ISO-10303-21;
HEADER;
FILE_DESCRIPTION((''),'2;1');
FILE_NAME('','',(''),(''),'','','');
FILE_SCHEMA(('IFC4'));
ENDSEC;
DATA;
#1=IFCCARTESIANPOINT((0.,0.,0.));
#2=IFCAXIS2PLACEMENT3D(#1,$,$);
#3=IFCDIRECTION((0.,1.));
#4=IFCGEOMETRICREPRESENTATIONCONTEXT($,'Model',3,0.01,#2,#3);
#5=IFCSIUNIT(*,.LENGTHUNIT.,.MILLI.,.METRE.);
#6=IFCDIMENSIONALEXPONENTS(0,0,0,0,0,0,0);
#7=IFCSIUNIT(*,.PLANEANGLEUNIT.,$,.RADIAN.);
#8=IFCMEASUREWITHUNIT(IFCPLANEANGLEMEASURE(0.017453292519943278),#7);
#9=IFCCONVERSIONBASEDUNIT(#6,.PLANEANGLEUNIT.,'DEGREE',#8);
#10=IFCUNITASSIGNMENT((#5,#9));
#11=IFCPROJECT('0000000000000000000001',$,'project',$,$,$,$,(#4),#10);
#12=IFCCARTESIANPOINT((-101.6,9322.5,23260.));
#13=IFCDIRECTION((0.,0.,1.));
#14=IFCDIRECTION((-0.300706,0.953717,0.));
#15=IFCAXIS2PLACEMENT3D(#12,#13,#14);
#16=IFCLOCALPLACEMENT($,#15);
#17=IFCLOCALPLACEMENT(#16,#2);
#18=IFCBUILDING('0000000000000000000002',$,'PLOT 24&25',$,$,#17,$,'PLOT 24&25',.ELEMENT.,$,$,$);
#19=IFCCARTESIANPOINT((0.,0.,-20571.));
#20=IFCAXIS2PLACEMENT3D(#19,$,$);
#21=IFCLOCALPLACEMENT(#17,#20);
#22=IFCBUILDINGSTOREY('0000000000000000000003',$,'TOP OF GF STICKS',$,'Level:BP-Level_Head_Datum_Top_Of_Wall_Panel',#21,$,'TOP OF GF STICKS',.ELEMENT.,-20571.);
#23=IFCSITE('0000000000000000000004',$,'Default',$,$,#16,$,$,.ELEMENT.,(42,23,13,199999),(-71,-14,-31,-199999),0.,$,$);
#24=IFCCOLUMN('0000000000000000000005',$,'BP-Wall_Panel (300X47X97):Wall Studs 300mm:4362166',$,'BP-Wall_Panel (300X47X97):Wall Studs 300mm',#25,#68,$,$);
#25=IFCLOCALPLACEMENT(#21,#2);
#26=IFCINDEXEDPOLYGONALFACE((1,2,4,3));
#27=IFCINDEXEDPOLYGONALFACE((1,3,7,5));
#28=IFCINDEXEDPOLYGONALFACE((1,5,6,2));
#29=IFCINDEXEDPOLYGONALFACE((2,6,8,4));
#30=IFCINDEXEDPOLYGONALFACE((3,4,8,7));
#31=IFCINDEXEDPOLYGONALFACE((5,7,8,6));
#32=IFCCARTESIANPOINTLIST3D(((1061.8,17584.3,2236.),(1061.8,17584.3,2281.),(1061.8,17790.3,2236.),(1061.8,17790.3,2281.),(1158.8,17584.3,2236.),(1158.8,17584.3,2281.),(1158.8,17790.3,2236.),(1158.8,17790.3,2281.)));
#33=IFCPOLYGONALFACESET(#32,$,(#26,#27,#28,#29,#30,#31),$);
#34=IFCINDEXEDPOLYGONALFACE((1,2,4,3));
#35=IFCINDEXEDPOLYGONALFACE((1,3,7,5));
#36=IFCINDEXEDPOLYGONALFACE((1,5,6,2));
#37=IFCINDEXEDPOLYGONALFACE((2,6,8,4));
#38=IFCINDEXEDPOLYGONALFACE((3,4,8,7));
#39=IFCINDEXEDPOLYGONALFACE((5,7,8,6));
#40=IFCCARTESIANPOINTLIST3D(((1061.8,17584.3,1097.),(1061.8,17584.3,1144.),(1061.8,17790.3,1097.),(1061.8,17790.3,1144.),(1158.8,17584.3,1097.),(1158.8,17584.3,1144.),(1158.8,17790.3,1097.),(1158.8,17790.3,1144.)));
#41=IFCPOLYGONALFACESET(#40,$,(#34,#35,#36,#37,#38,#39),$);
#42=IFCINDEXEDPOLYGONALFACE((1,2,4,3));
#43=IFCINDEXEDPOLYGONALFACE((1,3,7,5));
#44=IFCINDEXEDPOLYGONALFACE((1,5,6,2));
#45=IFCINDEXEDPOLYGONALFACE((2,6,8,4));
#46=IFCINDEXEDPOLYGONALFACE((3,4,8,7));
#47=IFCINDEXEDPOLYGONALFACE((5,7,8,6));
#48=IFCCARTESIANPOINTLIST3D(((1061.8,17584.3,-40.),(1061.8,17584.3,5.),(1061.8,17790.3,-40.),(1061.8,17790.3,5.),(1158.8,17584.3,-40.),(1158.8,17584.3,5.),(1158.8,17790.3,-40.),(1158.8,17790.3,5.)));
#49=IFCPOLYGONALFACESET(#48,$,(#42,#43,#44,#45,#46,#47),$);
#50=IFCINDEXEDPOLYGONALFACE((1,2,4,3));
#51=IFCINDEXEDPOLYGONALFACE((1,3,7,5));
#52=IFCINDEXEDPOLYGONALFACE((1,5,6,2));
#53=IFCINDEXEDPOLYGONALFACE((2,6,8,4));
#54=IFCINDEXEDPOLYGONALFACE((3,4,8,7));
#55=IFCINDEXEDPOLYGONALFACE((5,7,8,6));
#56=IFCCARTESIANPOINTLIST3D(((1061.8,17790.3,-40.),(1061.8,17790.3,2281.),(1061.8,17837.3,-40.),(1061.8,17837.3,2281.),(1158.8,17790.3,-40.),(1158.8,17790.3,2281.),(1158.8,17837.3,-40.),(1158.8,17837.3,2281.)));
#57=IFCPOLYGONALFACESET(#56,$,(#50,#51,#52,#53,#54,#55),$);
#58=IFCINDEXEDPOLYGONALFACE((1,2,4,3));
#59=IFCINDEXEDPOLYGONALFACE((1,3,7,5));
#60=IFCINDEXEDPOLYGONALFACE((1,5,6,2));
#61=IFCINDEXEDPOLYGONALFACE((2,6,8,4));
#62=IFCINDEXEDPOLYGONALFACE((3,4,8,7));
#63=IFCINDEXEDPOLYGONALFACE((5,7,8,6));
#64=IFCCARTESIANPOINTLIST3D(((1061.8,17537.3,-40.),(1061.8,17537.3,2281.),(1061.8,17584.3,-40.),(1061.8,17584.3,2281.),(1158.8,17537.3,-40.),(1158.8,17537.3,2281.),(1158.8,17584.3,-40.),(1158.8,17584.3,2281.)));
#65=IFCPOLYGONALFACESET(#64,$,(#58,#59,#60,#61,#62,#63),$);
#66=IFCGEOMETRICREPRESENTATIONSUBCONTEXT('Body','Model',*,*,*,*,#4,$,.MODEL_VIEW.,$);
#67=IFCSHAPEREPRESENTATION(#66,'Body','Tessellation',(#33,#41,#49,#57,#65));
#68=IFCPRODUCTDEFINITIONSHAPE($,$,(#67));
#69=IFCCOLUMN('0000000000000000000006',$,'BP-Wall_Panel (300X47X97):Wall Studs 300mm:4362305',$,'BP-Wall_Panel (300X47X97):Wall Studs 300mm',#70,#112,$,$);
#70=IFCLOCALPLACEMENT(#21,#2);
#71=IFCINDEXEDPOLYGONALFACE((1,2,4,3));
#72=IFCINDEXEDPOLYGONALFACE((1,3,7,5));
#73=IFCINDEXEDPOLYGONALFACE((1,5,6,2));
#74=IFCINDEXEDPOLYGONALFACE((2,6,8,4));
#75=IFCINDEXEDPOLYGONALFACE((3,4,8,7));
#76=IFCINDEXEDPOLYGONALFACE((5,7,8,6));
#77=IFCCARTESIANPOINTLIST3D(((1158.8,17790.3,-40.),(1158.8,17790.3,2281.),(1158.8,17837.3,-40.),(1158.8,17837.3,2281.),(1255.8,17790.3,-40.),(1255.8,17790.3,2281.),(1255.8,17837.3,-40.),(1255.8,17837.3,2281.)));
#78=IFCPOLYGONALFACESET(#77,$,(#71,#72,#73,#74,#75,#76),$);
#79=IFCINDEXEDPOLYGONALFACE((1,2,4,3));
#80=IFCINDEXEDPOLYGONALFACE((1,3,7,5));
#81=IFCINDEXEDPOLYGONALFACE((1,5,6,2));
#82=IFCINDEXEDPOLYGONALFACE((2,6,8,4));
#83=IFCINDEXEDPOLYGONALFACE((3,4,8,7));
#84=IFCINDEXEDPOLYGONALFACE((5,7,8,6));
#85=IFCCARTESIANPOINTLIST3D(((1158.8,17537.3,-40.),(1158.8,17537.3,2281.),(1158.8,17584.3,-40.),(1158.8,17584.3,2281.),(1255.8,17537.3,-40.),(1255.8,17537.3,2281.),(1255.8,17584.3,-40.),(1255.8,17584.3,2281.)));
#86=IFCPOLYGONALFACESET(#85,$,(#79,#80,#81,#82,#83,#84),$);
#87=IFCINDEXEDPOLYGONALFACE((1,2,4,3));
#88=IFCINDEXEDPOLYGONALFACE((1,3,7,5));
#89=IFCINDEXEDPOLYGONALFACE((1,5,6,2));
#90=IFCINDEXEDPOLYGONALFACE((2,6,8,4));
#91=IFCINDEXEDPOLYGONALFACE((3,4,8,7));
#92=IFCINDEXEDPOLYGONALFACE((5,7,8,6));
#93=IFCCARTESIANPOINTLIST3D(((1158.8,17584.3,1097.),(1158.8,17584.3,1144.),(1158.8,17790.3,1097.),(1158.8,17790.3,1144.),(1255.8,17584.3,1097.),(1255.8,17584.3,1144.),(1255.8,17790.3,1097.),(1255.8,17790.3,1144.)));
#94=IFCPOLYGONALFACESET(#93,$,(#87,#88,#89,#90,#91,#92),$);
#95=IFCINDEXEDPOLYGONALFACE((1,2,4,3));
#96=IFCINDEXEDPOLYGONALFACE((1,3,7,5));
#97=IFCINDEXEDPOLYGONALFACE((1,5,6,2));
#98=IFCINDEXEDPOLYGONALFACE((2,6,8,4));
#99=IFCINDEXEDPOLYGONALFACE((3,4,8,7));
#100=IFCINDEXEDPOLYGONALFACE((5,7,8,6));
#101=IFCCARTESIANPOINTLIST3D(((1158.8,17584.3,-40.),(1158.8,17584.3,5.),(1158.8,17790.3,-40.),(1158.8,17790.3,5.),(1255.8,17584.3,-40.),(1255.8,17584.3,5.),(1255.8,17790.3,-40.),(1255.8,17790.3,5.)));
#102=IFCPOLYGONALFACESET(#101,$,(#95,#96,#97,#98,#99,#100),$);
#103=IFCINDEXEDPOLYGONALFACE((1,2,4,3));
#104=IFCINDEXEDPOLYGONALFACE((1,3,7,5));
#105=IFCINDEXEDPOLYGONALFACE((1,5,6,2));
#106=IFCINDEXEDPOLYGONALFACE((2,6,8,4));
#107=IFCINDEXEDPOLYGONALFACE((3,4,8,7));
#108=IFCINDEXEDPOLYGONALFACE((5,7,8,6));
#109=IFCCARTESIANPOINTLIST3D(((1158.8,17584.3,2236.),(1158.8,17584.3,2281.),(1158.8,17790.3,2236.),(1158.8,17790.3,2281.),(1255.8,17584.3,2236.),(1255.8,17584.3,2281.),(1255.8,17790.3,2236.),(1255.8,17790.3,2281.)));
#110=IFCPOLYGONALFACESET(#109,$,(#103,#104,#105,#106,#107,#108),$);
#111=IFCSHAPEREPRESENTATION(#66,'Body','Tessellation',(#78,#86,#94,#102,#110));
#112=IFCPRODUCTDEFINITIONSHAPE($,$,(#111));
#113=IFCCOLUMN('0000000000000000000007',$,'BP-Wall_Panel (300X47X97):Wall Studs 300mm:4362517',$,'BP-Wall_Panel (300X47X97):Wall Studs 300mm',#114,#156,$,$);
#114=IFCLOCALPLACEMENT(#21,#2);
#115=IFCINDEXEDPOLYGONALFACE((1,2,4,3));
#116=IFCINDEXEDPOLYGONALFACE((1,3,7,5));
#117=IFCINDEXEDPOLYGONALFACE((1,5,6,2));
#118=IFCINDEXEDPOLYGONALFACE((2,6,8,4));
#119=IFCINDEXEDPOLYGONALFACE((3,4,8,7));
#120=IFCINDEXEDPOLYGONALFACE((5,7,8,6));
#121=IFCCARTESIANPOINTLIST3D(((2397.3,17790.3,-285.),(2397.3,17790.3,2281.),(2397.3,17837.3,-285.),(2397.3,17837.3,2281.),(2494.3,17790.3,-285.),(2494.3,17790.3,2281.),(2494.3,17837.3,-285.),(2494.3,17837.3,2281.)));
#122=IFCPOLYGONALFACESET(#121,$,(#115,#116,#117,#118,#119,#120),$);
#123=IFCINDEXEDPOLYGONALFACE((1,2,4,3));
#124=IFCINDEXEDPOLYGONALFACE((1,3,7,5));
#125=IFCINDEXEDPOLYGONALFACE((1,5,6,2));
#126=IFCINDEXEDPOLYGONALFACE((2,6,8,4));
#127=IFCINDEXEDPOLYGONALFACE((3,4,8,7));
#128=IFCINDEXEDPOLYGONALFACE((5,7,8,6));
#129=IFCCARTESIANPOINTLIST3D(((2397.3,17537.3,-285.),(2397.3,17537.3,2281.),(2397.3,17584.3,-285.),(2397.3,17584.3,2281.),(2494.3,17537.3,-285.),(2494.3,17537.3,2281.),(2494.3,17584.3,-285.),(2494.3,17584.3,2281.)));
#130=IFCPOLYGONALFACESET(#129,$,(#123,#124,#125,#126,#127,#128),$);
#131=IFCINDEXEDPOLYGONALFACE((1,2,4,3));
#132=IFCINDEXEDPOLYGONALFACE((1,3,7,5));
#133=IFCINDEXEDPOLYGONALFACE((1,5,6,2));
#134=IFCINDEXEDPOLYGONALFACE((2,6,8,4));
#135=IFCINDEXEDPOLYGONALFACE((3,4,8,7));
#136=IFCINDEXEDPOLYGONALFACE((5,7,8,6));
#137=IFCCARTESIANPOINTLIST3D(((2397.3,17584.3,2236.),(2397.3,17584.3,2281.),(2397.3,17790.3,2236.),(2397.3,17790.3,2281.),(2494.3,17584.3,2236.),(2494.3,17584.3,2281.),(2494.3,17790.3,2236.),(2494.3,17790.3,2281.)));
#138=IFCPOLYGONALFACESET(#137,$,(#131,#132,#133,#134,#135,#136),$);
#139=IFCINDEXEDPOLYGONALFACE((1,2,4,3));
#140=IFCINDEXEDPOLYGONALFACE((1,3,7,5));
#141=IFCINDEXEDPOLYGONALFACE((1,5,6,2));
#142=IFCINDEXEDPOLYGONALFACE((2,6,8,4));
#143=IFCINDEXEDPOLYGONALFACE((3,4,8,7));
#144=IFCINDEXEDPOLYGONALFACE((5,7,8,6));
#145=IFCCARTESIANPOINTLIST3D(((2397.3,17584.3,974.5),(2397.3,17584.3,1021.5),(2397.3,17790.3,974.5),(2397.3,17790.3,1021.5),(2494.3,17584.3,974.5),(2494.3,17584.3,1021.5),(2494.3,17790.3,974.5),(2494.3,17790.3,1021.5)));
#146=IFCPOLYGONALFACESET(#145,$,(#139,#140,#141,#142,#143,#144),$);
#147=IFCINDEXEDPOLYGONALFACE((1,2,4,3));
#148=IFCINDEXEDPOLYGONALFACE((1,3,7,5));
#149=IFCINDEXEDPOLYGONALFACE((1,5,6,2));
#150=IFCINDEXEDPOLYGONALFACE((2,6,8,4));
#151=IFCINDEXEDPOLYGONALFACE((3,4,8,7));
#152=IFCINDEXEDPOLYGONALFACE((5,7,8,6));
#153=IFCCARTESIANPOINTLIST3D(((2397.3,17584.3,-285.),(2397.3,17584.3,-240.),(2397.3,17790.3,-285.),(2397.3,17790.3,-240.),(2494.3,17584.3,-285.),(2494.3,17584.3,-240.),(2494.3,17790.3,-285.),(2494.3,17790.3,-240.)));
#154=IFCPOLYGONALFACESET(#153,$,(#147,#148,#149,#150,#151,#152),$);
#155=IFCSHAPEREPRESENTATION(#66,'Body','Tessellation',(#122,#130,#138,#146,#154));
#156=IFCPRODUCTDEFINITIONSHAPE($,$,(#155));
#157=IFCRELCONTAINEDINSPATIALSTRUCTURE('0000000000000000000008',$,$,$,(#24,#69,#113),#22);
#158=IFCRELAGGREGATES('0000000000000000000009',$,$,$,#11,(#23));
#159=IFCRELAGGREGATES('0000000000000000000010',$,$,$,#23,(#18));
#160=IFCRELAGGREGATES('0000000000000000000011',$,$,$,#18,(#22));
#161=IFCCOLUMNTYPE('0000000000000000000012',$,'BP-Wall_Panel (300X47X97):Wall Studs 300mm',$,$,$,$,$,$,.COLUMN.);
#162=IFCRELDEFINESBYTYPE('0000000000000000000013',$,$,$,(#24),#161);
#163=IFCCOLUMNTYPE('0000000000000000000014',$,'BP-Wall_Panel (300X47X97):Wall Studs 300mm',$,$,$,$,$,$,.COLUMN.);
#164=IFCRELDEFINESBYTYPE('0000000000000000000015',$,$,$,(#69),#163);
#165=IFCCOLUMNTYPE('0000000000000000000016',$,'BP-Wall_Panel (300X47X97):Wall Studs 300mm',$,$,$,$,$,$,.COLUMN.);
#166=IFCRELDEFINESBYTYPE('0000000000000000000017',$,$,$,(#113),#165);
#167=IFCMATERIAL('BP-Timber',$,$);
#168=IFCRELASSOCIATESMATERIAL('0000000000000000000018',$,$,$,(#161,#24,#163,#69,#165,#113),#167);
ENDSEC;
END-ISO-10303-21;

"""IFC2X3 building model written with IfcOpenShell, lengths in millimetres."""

from ifc_helpers import new_model, entity, si_unit, converted_unit, direction, frame, frame_2d, origin, place, context, subcontext, project, spatial, rectangle, extrude, source, transform, mapped, material, type_object, type_shapes, element, save


model = new_model("IFC2X3")

# Units and contexts
model_context = context("Model", 3, precision=0.01, world=origin(), true_north=direction((0.0, 1.0)))
body_context = subcontext(model_context, "Body", "Model", "MODEL_VIEW")
ifc_project = project(units=[si_unit("LENGTHUNIT", "METRE", prefix="MILLI"), converted_unit("PLANEANGLEUNIT", "DEGREE", entity("IfcPlaneAngleMeasure", 0.017453292519943278), si_unit("PLANEANGLEUNIT", "RADIAN"), dimensions=[0, 0, 0, 0, 0, 0, 0])], contexts=[model_context])

# Site, building, storey
site_placement = place(None, frame((-101.6, 9322.5, 23260.0), z_axis=(0.0, 0.0, 1.0), x_axis=(-0.300706, 0.953717, 0.0)))
site = spatial("IfcSite", under=ifc_project, at=site_placement, Name="Default", CompositionType="ELEMENT", RefLatitude=(42, 23, 13, 199999), RefLongitude=(-71, -14, -31, -199999), RefElevation=0.0)
building_placement = place(site_placement, origin())
building = spatial("IfcBuilding", under=site, at=building_placement, Name="PLOT 24&25", LongName="PLOT 24&25", CompositionType="ELEMENT")
storey_placement = place(building_placement, frame((0.0, 0.0, -20571.0)))
storey = spatial("IfcBuildingStorey", under=building, at=storey_placement, Name="TOP OF GF STICKS", ObjectType="Level:BP-Level_Head_Datum_Top_Of_Wall_Panel", LongName="TOP OF GF STICKS", CompositionType="ELEMENT", Elevation=-20571.0)

# Columns
ifc_material_1 = material(Name="BP-Timber")
column_type_1 = type_object("IfcColumnType", Name="BP-Wall_Panel (300X47X97):Wall Studs 300mm", PredefinedType="COLUMN", material=ifc_material_1)
shared_shape_1 = source(origin(), body_context, "Body", "SweptSolid", [
    extrude(rectangle(XDim=206.0, YDim=97.0, at=frame_2d((0.0, 0.0), x_axis=(1.0, 0.0))), frame((1110.3, 17687.3, -18335.0), z_axis=(0.0, 0.0, 1.0), x_axis=(0.0, -1.0, 0.0)), (0.0, 0.0, 1.0), 45.0),
    extrude(rectangle(XDim=206.0, YDim=97.0, at=frame_2d((0.0, 0.0), x_axis=(1.0, 0.0))), frame((1110.3, 17687.3, -19474.0), z_axis=(0.0, 0.0, 1.0), x_axis=(0.0, -1.0, 0.0)), (0.0, 0.0, 1.0), 47.0),
    extrude(rectangle(XDim=206.0, YDim=97.0, at=frame_2d((0.0, 0.0), x_axis=(1.0, 0.0))), frame((1110.3, 17687.3, -20611.0), z_axis=(0.0, 0.0, 1.0), x_axis=(0.0, -1.0, 0.0)), (0.0, 0.0, 1.0), 45.0),
    extrude(rectangle(XDim=97.0, YDim=47.0, at=frame_2d((0.0, 0.0), x_axis=(1.0, 0.0))), frame((1110.3, 17813.8, -20611.0), z_axis=(0.0, 0.0, 1.0), x_axis=(-1.0, 0.0, 0.0)), (0.0, 0.0, 1.0), 2321.0),
    extrude(rectangle(XDim=97.0, YDim=47.0, at=frame_2d((0.0, 0.0), x_axis=(1.0, 0.0))), frame((1110.3, 17560.8, -20611.0), z_axis=(0.0, 0.0, 1.0), x_axis=(-1.0, 0.0, 0.0)), (0.0, 0.0, 1.0), 2321.0),
])
type_shapes(column_type_1, [shared_shape_1])
column_1_placement = place(storey_placement, frame((0.0, 0.0, 20571.0)))
element("IfcColumn", 1, at=column_1_placement, inside=storey, type_object=column_type_1, material=ifc_material_1, Name="BP-Wall_Panel (300X47X97):Wall Studs 300mm:4362166", ObjectType="BP-Wall_Panel (300X47X97):Wall Studs 300mm", context=body_context, shape_type="MappedRepresentation", body=[
    mapped(shared_shape_1, transform((0.0, 0.0, 0.0), scale=1.0)),
])
column_type_2 = type_object("IfcColumnType", Name="BP-Wall_Panel (300X47X97):Wall Studs 300mm", PredefinedType="COLUMN", material=ifc_material_1)
shared_shape_2 = source(origin(), body_context, "Body", "SweptSolid", [
    extrude(rectangle(XDim=97.0, YDim=47.0, at=frame_2d((0.0, 0.0), x_axis=(1.0, 0.0))), frame((1207.3, 17813.8, -20611.0), z_axis=(0.0, 0.0, 1.0), x_axis=(-1.0, 0.0, 0.0)), (0.0, 0.0, 1.0), 2321.0),
    extrude(rectangle(XDim=97.0, YDim=47.0, at=frame_2d((0.0, 0.0), x_axis=(1.0, 0.0))), frame((1207.3, 17560.8, -20611.0), z_axis=(0.0, 0.0, 1.0), x_axis=(-1.0, 0.0, 0.0)), (0.0, 0.0, 1.0), 2321.0),
    extrude(rectangle(XDim=206.0, YDim=97.0, at=frame_2d((0.0, 0.0), x_axis=(1.0, 0.0))), frame((1207.3, 17687.3, -19474.0), z_axis=(0.0, 0.0, 1.0), x_axis=(0.0, -1.0, 0.0)), (0.0, 0.0, 1.0), 47.0),
    extrude(rectangle(XDim=206.0, YDim=97.0, at=frame_2d((0.0, 0.0), x_axis=(1.0, 0.0))), frame((1207.3, 17687.3, -20611.0), z_axis=(0.0, 0.0, 1.0), x_axis=(0.0, -1.0, 0.0)), (0.0, 0.0, 1.0), 45.0),
    extrude(rectangle(XDim=206.0, YDim=97.0, at=frame_2d((0.0, 0.0), x_axis=(1.0, 0.0))), frame((1207.3, 17687.3, -18335.0), z_axis=(0.0, 0.0, 1.0), x_axis=(0.0, -1.0, 0.0)), (0.0, 0.0, 1.0), 45.0),
])
type_shapes(column_type_2, [shared_shape_2])
column_2_placement = place(storey_placement, frame((0.0, 0.0, 20571.0)))
element("IfcColumn", 2, at=column_2_placement, inside=storey, type_object=column_type_2, material=ifc_material_1, Name="BP-Wall_Panel (300X47X97):Wall Studs 300mm:4362305", ObjectType="BP-Wall_Panel (300X47X97):Wall Studs 300mm", context=body_context, shape_type="MappedRepresentation", body=[
    mapped(shared_shape_2, transform((0.0, 0.0, 0.0), scale=1.0)),
])
column_type_3 = type_object("IfcColumnType", Name="BP-Wall_Panel (300X47X97):Wall Studs 300mm", PredefinedType="COLUMN", material=ifc_material_1)
shared_shape_3 = source(origin(), body_context, "Body", "SweptSolid", [
    extrude(rectangle(XDim=97.0, YDim=47.0, at=frame_2d((0.0, 0.0), x_axis=(1.0, 0.0))), frame((2445.8, 17813.8, -20856.0), z_axis=(0.0, 0.0, 1.0), x_axis=(-1.0, 0.0, 0.0)), (0.0, 0.0, 1.0), 2566.0),
    extrude(rectangle(XDim=97.0, YDim=47.0, at=frame_2d((0.0, 0.0), x_axis=(1.0, 0.0))), frame((2445.8, 17560.8, -20856.0), z_axis=(0.0, 0.0, 1.0), x_axis=(-1.0, 0.0, 0.0)), (0.0, 0.0, 1.0), 2566.0),
    extrude(rectangle(XDim=206.0, YDim=97.0, at=frame_2d((0.0, 0.0), x_axis=(1.0, 0.0))), frame((2445.8, 17687.3, -18335.0), z_axis=(0.0, 0.0, 1.0), x_axis=(0.0, -1.0, 0.0)), (0.0, 0.0, 1.0), 45.0),
    extrude(rectangle(XDim=206.0, YDim=97.0, at=frame_2d((0.0, 0.0), x_axis=(1.0, 0.0))), frame((2445.8, 17687.3, -19596.5), z_axis=(0.0, 0.0, 1.0), x_axis=(0.0, -1.0, 0.0)), (0.0, 0.0, 1.0), 47.0),
    extrude(rectangle(XDim=206.0, YDim=97.0, at=frame_2d((0.0, 0.0), x_axis=(1.0, 0.0))), frame((2445.8, 17687.3, -20856.0), z_axis=(0.0, 0.0, 1.0), x_axis=(0.0, -1.0, 0.0)), (0.0, 0.0, 1.0), 45.0),
])
type_shapes(column_type_3, [shared_shape_3])
column_3_placement = place(storey_placement, frame((0.0, 0.0, 20571.0)))
element("IfcColumn", 3, at=column_3_placement, inside=storey, type_object=column_type_3, material=ifc_material_1, Name="BP-Wall_Panel (300X47X97):Wall Studs 300mm:4362517", ObjectType="BP-Wall_Panel (300X47X97):Wall Studs 300mm", context=body_context, shape_type="MappedRepresentation", body=[
    mapped(shared_shape_3, transform((0.0, 0.0, 0.0), scale=1.0)),
])

save(model, "model.ifc")
